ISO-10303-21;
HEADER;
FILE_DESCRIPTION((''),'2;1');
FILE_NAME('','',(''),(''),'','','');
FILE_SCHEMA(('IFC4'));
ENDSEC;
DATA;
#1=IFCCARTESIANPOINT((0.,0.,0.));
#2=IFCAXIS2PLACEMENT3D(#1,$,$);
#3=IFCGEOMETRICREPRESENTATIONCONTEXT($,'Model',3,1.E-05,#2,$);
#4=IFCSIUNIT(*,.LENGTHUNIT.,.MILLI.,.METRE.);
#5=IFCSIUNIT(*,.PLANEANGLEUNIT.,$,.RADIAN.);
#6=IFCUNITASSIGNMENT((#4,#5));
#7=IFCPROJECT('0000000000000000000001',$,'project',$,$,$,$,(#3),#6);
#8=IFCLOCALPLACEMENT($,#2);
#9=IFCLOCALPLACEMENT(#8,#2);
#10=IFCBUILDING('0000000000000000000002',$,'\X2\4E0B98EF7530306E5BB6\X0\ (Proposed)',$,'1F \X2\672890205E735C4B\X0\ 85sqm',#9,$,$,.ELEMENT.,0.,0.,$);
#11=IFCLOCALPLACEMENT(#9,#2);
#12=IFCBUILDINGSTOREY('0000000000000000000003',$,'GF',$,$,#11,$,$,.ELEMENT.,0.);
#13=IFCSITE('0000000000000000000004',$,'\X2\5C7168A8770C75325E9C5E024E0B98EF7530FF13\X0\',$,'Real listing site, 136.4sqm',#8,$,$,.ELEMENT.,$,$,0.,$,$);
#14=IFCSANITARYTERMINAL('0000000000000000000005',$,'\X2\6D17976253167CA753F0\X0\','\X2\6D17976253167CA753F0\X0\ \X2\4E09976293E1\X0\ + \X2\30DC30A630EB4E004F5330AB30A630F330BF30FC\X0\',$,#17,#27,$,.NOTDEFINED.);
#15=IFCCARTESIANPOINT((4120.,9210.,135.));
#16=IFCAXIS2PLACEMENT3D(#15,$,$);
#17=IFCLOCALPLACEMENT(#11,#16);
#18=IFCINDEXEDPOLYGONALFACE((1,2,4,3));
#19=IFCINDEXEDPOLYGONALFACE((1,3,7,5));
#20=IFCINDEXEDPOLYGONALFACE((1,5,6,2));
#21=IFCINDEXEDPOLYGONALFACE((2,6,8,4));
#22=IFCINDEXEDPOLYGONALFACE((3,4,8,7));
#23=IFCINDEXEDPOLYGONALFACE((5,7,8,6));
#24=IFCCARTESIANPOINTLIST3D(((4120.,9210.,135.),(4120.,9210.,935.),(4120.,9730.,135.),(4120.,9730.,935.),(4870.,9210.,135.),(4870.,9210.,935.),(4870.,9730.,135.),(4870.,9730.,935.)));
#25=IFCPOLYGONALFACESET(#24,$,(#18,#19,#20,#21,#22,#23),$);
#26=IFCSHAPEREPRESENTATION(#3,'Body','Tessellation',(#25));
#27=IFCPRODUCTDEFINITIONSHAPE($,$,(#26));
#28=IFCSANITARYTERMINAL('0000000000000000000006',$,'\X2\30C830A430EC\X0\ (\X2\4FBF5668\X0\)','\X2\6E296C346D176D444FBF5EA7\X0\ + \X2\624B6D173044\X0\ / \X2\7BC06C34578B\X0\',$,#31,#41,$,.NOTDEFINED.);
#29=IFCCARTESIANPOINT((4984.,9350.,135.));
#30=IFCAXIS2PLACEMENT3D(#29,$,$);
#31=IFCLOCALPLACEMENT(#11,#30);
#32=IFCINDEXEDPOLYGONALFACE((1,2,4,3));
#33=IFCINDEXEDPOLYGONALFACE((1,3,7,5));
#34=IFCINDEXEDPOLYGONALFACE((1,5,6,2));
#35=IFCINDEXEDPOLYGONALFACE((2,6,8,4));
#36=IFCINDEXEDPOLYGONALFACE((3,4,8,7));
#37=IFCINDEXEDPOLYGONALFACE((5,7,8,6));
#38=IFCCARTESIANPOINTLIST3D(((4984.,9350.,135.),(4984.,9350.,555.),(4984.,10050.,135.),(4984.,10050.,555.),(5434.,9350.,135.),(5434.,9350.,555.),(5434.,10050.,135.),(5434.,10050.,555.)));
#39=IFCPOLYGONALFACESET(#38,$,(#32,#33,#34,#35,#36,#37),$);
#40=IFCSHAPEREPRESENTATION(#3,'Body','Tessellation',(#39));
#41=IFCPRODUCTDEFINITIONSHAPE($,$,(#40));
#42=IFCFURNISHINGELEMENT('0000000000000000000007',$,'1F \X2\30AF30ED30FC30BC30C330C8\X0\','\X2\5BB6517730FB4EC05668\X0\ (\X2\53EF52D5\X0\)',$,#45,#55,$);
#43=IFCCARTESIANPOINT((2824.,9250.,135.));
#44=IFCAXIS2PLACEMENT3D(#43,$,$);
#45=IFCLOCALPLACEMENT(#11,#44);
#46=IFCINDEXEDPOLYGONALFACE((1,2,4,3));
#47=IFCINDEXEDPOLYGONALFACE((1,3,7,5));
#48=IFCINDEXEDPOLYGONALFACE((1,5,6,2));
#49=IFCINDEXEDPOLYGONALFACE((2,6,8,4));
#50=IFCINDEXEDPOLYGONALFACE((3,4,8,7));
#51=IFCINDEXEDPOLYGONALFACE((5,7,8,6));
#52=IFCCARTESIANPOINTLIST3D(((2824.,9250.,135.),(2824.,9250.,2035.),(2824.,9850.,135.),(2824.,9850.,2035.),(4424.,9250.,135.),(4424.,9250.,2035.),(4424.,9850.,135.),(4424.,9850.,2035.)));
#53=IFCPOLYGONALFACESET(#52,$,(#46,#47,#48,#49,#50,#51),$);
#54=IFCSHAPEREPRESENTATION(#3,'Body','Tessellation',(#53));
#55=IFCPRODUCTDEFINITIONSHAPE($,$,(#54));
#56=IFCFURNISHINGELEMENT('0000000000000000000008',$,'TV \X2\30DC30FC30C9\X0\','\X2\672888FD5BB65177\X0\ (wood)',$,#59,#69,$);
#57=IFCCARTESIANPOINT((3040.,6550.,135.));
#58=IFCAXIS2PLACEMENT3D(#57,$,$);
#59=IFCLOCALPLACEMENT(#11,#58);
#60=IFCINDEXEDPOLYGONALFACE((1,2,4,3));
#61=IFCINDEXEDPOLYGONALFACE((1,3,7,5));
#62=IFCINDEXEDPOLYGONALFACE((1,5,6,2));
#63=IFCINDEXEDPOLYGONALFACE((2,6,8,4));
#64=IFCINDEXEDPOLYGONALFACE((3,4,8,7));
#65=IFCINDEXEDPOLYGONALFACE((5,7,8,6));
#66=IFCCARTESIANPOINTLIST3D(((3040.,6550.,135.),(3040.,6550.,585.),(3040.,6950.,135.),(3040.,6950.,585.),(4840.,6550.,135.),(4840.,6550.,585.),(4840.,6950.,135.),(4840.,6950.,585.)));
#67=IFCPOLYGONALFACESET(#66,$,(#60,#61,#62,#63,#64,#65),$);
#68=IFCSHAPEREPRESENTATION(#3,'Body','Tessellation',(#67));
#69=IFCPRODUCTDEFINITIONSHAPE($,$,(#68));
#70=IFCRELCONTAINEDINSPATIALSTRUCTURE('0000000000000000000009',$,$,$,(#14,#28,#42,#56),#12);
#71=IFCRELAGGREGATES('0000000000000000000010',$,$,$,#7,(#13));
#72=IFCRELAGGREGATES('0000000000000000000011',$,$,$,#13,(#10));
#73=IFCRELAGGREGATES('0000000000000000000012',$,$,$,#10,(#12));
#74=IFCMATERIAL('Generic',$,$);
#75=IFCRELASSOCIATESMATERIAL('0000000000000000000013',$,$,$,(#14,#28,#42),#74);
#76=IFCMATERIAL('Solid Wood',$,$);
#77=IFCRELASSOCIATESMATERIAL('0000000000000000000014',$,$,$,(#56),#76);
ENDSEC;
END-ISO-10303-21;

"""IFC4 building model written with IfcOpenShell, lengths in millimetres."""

from ifc_helpers import new_model, si_unit, frame, frame_2d, origin, place, context, project, spatial, rectangle, extrude, material, element, save


model = new_model("IFC4")

# Units and contexts
model_context = context("Model", 3, precision=1e-05, world=origin())
ifc_project = project(units=[si_unit("LENGTHUNIT", "METRE", prefix="MILLI"), si_unit("PLANEANGLEUNIT", "RADIAN")], contexts=[model_context])

# Site, building, storey
site_placement = place(None, origin())
site = spatial("IfcSite", under=ifc_project, at=site_placement, Name="山梨県甲府市下飯田３", ObjectType="Real listing site, 136.4sqm", CompositionType="ELEMENT", RefElevation=0.0)
building_placement = place(site_placement, origin())
building = spatial("IfcBuilding", under=site, at=building_placement, Name="下飯田の家 (Proposed)", ObjectType="1F 木造平屋 85sqm", CompositionType="ELEMENT", ElevationOfRefHeight=0.0, ElevationOfTerrain=0.0)
storey_placement = place(building_placement, origin())
storey = spatial("IfcBuildingStorey", under=building, at=storey_placement, Name="GF", CompositionType="ELEMENT", Elevation=0.0)

# Shared definitions
ifc_material_1 = material(Name="Solid Wood")

# Shared definitions
ifc_material_2 = material(Name="Generic")

# Sanitary terminals
sanitary_terminal_1_placement = place(storey_placement, frame((4120.0, 9210.0, 135.0)))
element("IfcSanitaryTerminal", 1, at=sanitary_terminal_1_placement, inside=storey, material=ifc_material_2, Name="洗面化粧台", Description="洗面化粧台 三面鏡 + ボウル一体カウンター", PredefinedType="NOTDEFINED", context=model_context, shape_type="SweptSolid", body=[
    extrude(rectangle(XDim=750.0, YDim=520.0, at=frame_2d((375.0, 260.0))), frame((4120.0, 9210.0, 135.0)), (0.0, 0.0, 1.0), 800.0),
])
sanitary_terminal_2_placement = place(storey_placement, frame((4984.0, 9350.0, 135.0)))
element("IfcSanitaryTerminal", 2, at=sanitary_terminal_2_placement, inside=storey, material=ifc_material_2, Name="トイレ (便器)", Description="温水洗浄便座 + 手洗い / 節水型", PredefinedType="NOTDEFINED", context=model_context, shape_type="SweptSolid", body=[
    extrude(rectangle(XDim=450.0, YDim=700.0, at=frame_2d((225.0, 350.0))), frame((4984.0, 9350.0, 135.0)), (0.0, 0.0, 1.0), 420.0),
])

# Furnishing elements
furnishing_1_placement = place(storey_placement, frame((2824.0, 9250.0, 135.0)))
element("IfcFurnishingElement", 3, at=furnishing_1_placement, inside=storey, material=ifc_material_2, Name="1F クローゼット", Description="家具・什器 (可動)", context=model_context, shape_type="SweptSolid", body=[
    extrude(rectangle(XDim=1600.0, YDim=600.0, at=frame_2d((800.0, 300.0))), frame((2824.0, 9250.0, 135.0)), (0.0, 0.0, 1.0), 1900.0),
])
furnishing_2_placement = place(storey_placement, frame((3040.0, 6550.0, 135.0)))
element("IfcFurnishingElement", 4, at=furnishing_2_placement, inside=storey, material=ifc_material_1, Name="TV ボード", Description="木製家具 (wood)", context=model_context, shape_type="SweptSolid", body=[
    extrude(rectangle(XDim=1800.0, YDim=400.0, at=frame_2d((900.0, 200.0))), frame((3040.0, 6550.0, 135.0)), (0.0, 0.0, 1.0), 450.0),
])

save(model, "model.ifc")
